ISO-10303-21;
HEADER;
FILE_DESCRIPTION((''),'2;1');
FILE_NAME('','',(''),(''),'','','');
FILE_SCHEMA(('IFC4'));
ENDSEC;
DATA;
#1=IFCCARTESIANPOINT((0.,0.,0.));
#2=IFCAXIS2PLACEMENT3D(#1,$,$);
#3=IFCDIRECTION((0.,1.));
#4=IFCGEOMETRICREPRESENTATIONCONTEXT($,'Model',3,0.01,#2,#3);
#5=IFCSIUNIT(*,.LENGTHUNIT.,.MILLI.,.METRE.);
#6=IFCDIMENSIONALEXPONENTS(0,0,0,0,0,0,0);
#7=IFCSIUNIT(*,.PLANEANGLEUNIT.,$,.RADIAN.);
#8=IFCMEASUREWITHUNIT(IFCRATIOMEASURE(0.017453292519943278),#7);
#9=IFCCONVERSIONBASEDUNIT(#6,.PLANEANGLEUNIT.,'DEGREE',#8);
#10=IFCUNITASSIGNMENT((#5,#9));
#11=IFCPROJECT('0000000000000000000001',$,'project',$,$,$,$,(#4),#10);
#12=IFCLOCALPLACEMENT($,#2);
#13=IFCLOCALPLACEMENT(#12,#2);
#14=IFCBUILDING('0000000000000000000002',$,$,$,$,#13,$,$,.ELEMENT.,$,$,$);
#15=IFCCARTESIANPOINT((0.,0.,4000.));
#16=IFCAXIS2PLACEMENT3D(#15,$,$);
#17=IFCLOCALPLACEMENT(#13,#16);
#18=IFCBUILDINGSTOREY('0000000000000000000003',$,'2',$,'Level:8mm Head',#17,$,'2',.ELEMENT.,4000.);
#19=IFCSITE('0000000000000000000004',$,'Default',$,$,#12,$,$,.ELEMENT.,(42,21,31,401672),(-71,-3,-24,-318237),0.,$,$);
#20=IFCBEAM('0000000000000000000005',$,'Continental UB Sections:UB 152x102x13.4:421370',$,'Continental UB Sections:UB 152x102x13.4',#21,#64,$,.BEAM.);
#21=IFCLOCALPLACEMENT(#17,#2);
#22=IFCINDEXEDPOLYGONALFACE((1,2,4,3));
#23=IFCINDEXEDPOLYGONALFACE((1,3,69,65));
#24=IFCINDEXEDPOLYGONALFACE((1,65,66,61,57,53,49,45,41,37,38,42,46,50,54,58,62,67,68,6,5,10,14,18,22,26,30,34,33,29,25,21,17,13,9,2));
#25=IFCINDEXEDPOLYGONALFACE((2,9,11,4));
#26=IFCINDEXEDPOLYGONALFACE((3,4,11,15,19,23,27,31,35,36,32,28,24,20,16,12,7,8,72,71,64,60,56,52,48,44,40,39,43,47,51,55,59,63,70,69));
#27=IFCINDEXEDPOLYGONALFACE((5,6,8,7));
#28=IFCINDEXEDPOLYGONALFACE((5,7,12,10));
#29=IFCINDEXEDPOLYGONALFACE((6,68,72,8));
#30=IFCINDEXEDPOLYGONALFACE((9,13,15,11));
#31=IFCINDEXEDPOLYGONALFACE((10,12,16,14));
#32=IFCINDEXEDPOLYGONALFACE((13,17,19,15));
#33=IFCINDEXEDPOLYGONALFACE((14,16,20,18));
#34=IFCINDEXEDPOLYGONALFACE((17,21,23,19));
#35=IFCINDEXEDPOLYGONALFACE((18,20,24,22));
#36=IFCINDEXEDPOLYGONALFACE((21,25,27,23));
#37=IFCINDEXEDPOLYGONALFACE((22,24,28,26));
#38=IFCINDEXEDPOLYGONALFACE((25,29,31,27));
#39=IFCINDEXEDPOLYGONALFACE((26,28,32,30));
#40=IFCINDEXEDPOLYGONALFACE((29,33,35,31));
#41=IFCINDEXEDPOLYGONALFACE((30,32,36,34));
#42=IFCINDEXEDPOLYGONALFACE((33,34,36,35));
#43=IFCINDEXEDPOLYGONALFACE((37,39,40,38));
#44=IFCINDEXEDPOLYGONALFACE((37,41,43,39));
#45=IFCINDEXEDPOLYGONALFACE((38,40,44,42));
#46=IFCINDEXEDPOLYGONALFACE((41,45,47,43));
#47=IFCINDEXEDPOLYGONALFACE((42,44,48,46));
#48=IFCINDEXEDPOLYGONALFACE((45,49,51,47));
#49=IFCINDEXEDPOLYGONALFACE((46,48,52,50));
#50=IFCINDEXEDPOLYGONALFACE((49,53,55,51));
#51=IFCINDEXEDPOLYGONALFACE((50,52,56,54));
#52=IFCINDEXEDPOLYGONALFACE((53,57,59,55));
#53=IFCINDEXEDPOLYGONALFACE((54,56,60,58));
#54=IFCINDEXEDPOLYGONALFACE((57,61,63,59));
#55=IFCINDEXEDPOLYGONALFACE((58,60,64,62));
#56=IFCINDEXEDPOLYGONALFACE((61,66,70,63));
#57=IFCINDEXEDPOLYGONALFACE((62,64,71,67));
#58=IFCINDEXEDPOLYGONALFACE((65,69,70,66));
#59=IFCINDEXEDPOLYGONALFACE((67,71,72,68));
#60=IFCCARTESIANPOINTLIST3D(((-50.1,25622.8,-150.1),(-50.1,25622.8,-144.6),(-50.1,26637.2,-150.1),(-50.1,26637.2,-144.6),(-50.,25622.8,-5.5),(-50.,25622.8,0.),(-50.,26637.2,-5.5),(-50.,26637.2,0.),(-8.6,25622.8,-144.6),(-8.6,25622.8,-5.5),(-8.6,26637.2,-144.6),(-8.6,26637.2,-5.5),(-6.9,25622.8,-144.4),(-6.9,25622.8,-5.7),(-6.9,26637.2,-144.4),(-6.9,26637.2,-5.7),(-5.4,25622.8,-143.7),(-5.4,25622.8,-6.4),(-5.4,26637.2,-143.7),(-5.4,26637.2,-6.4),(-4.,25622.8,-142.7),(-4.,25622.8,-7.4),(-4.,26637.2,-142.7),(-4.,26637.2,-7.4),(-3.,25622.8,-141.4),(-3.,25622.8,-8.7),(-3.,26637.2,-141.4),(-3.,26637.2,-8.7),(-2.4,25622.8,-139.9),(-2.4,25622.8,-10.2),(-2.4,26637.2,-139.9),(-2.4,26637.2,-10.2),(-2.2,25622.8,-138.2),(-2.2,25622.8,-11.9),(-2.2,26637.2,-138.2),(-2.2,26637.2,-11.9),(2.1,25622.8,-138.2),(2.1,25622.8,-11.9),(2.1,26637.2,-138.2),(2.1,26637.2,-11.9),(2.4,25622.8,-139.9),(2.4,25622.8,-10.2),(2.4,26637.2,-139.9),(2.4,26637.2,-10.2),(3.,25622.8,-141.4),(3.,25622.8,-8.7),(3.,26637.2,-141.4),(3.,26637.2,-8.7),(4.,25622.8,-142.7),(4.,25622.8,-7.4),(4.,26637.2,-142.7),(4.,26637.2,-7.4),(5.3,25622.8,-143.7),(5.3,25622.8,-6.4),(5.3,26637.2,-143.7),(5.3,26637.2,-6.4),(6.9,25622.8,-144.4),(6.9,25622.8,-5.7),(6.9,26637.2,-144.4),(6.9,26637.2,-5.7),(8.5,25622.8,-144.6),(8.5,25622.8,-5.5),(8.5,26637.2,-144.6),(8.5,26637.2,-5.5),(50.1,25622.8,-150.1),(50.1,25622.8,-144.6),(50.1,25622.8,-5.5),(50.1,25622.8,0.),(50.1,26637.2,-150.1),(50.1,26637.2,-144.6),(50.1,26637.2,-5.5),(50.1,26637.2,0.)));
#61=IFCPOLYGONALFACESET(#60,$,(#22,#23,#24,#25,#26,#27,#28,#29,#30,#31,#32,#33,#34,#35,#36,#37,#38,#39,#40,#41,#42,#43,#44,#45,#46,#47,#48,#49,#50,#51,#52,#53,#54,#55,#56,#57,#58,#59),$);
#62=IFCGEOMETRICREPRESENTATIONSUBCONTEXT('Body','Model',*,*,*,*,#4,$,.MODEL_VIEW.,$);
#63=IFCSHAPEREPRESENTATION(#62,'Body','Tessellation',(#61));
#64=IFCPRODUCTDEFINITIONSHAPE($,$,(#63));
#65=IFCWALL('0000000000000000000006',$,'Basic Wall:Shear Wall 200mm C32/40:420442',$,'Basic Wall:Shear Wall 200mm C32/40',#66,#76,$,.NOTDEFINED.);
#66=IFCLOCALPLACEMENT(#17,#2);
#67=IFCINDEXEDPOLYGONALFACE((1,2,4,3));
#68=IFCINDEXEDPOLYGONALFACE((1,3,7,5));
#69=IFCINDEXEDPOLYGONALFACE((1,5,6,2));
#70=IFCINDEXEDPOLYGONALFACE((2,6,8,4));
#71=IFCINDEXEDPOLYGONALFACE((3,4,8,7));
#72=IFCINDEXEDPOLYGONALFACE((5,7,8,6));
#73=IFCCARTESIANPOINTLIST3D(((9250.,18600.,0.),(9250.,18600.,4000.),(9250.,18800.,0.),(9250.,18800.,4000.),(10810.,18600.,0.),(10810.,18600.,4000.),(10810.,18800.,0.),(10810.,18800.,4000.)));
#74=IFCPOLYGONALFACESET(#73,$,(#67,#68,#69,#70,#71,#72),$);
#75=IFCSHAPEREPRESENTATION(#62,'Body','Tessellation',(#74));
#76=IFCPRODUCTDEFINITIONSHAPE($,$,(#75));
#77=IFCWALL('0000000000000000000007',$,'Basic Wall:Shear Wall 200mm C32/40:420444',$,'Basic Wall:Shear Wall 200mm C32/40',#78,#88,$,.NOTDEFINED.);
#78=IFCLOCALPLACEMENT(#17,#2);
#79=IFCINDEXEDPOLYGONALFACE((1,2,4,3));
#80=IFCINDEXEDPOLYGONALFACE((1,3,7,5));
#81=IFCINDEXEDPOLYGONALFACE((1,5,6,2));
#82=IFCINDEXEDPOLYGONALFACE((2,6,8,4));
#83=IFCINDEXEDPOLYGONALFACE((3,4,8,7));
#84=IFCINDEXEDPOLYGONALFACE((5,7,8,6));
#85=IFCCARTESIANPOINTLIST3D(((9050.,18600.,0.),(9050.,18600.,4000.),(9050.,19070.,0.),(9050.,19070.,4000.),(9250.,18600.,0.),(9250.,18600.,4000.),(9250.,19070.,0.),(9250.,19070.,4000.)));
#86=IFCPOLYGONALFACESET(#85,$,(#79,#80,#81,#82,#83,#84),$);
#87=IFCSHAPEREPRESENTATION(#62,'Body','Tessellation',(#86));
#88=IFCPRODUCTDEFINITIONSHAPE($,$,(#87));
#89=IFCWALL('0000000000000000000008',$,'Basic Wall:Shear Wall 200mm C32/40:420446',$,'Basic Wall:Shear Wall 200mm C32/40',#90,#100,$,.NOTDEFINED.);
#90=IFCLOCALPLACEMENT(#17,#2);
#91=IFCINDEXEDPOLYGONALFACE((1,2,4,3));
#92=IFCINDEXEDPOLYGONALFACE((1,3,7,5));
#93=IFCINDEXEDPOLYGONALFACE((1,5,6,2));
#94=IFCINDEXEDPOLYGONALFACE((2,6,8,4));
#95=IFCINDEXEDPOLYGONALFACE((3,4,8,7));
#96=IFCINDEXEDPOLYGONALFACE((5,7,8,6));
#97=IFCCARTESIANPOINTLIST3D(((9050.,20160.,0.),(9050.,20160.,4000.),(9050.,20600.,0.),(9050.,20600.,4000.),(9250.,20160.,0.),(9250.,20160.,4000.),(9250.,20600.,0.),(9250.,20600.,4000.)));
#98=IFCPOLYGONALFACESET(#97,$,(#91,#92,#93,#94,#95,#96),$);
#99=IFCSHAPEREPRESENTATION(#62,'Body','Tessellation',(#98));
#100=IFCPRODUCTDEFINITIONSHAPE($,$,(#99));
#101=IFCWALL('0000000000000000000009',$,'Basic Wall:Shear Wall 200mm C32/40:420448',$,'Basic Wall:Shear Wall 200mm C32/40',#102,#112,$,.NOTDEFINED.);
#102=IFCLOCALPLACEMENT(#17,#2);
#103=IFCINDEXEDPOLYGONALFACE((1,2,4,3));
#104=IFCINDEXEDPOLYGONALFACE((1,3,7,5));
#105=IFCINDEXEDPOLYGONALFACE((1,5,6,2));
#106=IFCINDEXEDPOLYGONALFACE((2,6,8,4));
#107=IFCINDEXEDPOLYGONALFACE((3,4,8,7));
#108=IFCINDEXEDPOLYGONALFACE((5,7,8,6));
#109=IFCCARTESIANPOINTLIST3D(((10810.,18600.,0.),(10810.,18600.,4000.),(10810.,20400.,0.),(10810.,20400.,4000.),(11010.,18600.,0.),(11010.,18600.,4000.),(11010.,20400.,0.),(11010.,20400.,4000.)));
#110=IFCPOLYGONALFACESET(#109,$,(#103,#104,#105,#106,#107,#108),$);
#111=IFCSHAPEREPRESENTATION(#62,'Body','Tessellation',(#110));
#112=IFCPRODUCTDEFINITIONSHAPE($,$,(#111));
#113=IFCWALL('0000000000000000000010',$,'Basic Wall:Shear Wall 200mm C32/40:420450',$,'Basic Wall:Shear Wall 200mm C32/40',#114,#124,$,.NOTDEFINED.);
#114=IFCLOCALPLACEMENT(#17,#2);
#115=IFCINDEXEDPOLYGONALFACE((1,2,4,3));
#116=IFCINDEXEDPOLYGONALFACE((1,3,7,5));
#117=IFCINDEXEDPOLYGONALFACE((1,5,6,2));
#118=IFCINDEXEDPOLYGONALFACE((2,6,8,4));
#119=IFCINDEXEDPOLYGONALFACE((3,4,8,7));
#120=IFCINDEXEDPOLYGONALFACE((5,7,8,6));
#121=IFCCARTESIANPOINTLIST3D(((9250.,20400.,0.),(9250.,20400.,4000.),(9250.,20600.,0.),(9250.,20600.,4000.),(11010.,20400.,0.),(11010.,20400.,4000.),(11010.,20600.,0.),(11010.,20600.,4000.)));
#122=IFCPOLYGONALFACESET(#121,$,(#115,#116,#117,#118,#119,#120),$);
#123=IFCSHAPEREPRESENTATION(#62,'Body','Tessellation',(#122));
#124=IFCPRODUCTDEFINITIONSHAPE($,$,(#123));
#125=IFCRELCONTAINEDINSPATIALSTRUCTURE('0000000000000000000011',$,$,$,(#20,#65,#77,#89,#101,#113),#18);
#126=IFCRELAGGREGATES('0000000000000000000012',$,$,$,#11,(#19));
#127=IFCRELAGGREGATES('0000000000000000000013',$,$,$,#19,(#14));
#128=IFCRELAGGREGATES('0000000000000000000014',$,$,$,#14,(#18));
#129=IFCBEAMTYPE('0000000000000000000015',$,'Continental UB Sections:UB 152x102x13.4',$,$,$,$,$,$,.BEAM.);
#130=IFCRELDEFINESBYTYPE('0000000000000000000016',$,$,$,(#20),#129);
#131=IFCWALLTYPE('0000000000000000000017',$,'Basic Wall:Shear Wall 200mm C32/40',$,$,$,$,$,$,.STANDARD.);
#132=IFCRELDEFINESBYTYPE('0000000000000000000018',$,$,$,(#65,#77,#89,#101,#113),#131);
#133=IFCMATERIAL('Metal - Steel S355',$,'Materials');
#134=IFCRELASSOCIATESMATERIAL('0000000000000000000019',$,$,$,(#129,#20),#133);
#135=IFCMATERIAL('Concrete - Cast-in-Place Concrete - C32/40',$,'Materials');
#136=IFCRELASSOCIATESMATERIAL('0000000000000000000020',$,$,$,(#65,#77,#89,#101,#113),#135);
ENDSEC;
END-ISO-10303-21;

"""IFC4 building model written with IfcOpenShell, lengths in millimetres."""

from ifc_helpers import new_model, entity, si_unit, converted_unit, direction, frame, origin, place, context, subcontext, project, spatial, line, arc, indexed_curve, outline, extrude, source, transform, mapped, material, type_object, type_shapes, element, save


model = new_model("IFC4")

# Units and contexts
model_context = context("Model", 3, precision=0.01, world=origin(), true_north=direction((0.0, 1.0)))
body_context = subcontext(model_context, "Body", "Model", "MODEL_VIEW")
ifc_project = project(units=[si_unit("LENGTHUNIT", "METRE", prefix="MILLI"), converted_unit("PLANEANGLEUNIT", "DEGREE", entity("IfcRatioMeasure", 0.017453292519943278), si_unit("PLANEANGLEUNIT", "RADIAN"), dimensions=[0, 0, 0, 0, 0, 0, 0])], contexts=[model_context])

# Site, building, storey
site_placement = place(None, origin())
site = spatial("IfcSite", under=ifc_project, at=site_placement, Name="Default", CompositionType="ELEMENT", RefLatitude=(42, 21, 31, 401672), RefLongitude=(-71, -3, -24, -318237), RefElevation=0.0)
building_placement = place(site_placement, origin())
building = spatial("IfcBuilding", under=site, at=building_placement, CompositionType="ELEMENT")
storey_placement = place(building_placement, frame((0.0, 0.0, 4000.0)))
storey = spatial("IfcBuildingStorey", under=building, at=storey_placement, Name="2", ObjectType="Level:8mm Head", LongName="2", CompositionType="ELEMENT", Elevation=4000.0)

# Beam
ifc_material_1 = material(Name="Metal - Steel S355", Category="Materials")
beam_type_1 = type_object("IfcBeamType", Name="Continental UB Sections:UB 152x102x13.4", PredefinedType="BEAM", material=ifc_material_1)
shared_shape_1 = source(origin(), body_context, "Body", "SweptSolid", [
    extrude(outline(indexed_curve([(-75.0, -50.1), (-69.6, -50.1), (-69.6, -8.5), (-67.7, -4.0), (-63.2, -2.1), (63.1, -2.1), (67.7, -4.0), (69.5, -8.5), (69.5, -50.1), (75.1, -50.1), (75.1, 50.1), (69.5, 50.1), (69.5, 8.6), (67.7, 4.0), (63.1, 2.2), (-63.2, 2.2), (-67.7, 4.0), (-69.6, 8.6), (-69.6, 50.0), (-75.0, 50.0)], segments=[line(1, 2, 3), arc(3, 4, 5), line(5, 6), arc(6, 7, 8), line(8, 9, 10, 11, 12, 13), arc(13, 14, 15), line(15, 16), arc(16, 17, 18), line(18, 19, 20, 1)], self_intersect=False)), frame((-507.2, 0.0, 0.0), z_axis=(1.0, 0.0, 0.0), x_axis=(0.0, 0.0, -1.0)), (0.0, 0.0, 1.0), 1014.4),
])
type_shapes(beam_type_1, [shared_shape_1])
beam_1_placement = place(storey_placement, frame((0.0, 26130.0, -75.1), z_axis=(0.0, 0.0, 1.0), x_axis=(0.0, 1.0, 0.0)))
element("IfcBeam", 1, at=beam_1_placement, inside=storey, type_object=beam_type_1, material=ifc_material_1, Name="Continental UB Sections:UB 152x102x13.4:421370", ObjectType="Continental UB Sections:UB 152x102x13.4", PredefinedType="BEAM", context=body_context, shape_type="MappedRepresentation", body=[
    mapped(shared_shape_1, transform((0.0, 0.0, 0.0), scale=1.0)),
])

# Walls
ifc_material_2 = material(Name="Concrete - Cast-in-Place Concrete - C32/40", Category="Materials")
wall_type = type_object("IfcWallType", Name="Basic Wall:Shear Wall 200mm C32/40", PredefinedType="STANDARD")
wall_1_placement = place(storey_placement, frame((10810.0, 18700.0, 0.0), z_axis=(0.0, 0.0, 1.0), x_axis=(-1.0, 0.0, 0.0)))
element("IfcWall", 2, at=wall_1_placement, inside=storey, type_object=wall_type, material=ifc_material_2, Name="Basic Wall:Shear Wall 200mm C32/40:420442", ObjectType="Basic Wall:Shear Wall 200mm C32/40", PredefinedType="NOTDEFINED", context=body_context, shape_type="SweptSolid", body=[
    extrude(outline(indexed_curve([(1560.0, 100.0), (0.0, 100.0), (0.0, -100.0), (1560.0, -100.0), (1560.0, 100.0)], self_intersect=False)), origin(), (0.0, 0.0, 1.0), 4000.0),
])
wall_2_placement = place(storey_placement, frame((9150.0, 19070.0, 0.0), z_axis=(0.0, 0.0, 1.0), x_axis=(0.0, -1.0, 0.0)))
element("IfcWall", 3, at=wall_2_placement, inside=storey, type_object=wall_type, material=ifc_material_2, Name="Basic Wall:Shear Wall 200mm C32/40:420444", ObjectType="Basic Wall:Shear Wall 200mm C32/40", PredefinedType="NOTDEFINED", context=body_context, shape_type="SweptSolid", body=[
    extrude(outline(indexed_curve([(470.0, 100.0), (0.0, 100.0), (0.0, -100.0), (470.0, -100.0), (470.0, 100.0)], self_intersect=False)), origin(), (0.0, 0.0, 1.0), 4000.0),
])
wall_3_placement = place(storey_placement, frame((9150.0, 20600.0, 0.0), z_axis=(0.0, 0.0, 1.0), x_axis=(0.0, -1.0, 0.0)))
element("IfcWall", 4, at=wall_3_placement, inside=storey, type_object=wall_type, material=ifc_material_2, Name="Basic Wall:Shear Wall 200mm C32/40:420446", ObjectType="Basic Wall:Shear Wall 200mm C32/40", PredefinedType="NOTDEFINED", context=body_context, shape_type="SweptSolid", body=[
    extrude(outline(indexed_curve([(440.0, 100.0), (0.0, 100.0), (0.0, -100.0), (440.0, -100.0), (440.0, 100.0)], self_intersect=False)), origin(), (0.0, 0.0, 1.0), 4000.0),
])
wall_4_placement = place(storey_placement, frame((10910.0, 20400.0, 0.0), z_axis=(0.0, 0.0, 1.0), x_axis=(0.0, -1.0, 0.0)))
element("IfcWall", 5, at=wall_4_placement, inside=storey, type_object=wall_type, material=ifc_material_2, Name="Basic Wall:Shear Wall 200mm C32/40:420448", ObjectType="Basic Wall:Shear Wall 200mm C32/40", PredefinedType="NOTDEFINED", context=body_context, shape_type="SweptSolid", body=[
    extrude(outline(indexed_curve([(1800.0, 100.0), (0.0, 100.0), (0.0, -100.0), (1800.0, -100.0), (1800.0, 100.0)], self_intersect=False)), origin(), (0.0, 0.0, 1.0), 4000.0),
])
wall_5_placement = place(storey_placement, frame((11010.0, 20500.0, 0.0), z_axis=(0.0, 0.0, 1.0), x_axis=(-1.0, 0.0, 0.0)))
element("IfcWall", 6, at=wall_5_placement, inside=storey, type_object=wall_type, material=ifc_material_2, Name="Basic Wall:Shear Wall 200mm C32/40:420450", ObjectType="Basic Wall:Shear Wall 200mm C32/40", PredefinedType="NOTDEFINED", context=body_context, shape_type="SweptSolid", body=[
    extrude(outline(indexed_curve([(1760.0, 100.0), (0.0, 100.0), (0.0, -100.0), (1760.0, -100.0), (1760.0, 100.0)], self_intersect=False)), origin(), (0.0, 0.0, 1.0), 4000.0),
])

save(model, "model.ifc")
